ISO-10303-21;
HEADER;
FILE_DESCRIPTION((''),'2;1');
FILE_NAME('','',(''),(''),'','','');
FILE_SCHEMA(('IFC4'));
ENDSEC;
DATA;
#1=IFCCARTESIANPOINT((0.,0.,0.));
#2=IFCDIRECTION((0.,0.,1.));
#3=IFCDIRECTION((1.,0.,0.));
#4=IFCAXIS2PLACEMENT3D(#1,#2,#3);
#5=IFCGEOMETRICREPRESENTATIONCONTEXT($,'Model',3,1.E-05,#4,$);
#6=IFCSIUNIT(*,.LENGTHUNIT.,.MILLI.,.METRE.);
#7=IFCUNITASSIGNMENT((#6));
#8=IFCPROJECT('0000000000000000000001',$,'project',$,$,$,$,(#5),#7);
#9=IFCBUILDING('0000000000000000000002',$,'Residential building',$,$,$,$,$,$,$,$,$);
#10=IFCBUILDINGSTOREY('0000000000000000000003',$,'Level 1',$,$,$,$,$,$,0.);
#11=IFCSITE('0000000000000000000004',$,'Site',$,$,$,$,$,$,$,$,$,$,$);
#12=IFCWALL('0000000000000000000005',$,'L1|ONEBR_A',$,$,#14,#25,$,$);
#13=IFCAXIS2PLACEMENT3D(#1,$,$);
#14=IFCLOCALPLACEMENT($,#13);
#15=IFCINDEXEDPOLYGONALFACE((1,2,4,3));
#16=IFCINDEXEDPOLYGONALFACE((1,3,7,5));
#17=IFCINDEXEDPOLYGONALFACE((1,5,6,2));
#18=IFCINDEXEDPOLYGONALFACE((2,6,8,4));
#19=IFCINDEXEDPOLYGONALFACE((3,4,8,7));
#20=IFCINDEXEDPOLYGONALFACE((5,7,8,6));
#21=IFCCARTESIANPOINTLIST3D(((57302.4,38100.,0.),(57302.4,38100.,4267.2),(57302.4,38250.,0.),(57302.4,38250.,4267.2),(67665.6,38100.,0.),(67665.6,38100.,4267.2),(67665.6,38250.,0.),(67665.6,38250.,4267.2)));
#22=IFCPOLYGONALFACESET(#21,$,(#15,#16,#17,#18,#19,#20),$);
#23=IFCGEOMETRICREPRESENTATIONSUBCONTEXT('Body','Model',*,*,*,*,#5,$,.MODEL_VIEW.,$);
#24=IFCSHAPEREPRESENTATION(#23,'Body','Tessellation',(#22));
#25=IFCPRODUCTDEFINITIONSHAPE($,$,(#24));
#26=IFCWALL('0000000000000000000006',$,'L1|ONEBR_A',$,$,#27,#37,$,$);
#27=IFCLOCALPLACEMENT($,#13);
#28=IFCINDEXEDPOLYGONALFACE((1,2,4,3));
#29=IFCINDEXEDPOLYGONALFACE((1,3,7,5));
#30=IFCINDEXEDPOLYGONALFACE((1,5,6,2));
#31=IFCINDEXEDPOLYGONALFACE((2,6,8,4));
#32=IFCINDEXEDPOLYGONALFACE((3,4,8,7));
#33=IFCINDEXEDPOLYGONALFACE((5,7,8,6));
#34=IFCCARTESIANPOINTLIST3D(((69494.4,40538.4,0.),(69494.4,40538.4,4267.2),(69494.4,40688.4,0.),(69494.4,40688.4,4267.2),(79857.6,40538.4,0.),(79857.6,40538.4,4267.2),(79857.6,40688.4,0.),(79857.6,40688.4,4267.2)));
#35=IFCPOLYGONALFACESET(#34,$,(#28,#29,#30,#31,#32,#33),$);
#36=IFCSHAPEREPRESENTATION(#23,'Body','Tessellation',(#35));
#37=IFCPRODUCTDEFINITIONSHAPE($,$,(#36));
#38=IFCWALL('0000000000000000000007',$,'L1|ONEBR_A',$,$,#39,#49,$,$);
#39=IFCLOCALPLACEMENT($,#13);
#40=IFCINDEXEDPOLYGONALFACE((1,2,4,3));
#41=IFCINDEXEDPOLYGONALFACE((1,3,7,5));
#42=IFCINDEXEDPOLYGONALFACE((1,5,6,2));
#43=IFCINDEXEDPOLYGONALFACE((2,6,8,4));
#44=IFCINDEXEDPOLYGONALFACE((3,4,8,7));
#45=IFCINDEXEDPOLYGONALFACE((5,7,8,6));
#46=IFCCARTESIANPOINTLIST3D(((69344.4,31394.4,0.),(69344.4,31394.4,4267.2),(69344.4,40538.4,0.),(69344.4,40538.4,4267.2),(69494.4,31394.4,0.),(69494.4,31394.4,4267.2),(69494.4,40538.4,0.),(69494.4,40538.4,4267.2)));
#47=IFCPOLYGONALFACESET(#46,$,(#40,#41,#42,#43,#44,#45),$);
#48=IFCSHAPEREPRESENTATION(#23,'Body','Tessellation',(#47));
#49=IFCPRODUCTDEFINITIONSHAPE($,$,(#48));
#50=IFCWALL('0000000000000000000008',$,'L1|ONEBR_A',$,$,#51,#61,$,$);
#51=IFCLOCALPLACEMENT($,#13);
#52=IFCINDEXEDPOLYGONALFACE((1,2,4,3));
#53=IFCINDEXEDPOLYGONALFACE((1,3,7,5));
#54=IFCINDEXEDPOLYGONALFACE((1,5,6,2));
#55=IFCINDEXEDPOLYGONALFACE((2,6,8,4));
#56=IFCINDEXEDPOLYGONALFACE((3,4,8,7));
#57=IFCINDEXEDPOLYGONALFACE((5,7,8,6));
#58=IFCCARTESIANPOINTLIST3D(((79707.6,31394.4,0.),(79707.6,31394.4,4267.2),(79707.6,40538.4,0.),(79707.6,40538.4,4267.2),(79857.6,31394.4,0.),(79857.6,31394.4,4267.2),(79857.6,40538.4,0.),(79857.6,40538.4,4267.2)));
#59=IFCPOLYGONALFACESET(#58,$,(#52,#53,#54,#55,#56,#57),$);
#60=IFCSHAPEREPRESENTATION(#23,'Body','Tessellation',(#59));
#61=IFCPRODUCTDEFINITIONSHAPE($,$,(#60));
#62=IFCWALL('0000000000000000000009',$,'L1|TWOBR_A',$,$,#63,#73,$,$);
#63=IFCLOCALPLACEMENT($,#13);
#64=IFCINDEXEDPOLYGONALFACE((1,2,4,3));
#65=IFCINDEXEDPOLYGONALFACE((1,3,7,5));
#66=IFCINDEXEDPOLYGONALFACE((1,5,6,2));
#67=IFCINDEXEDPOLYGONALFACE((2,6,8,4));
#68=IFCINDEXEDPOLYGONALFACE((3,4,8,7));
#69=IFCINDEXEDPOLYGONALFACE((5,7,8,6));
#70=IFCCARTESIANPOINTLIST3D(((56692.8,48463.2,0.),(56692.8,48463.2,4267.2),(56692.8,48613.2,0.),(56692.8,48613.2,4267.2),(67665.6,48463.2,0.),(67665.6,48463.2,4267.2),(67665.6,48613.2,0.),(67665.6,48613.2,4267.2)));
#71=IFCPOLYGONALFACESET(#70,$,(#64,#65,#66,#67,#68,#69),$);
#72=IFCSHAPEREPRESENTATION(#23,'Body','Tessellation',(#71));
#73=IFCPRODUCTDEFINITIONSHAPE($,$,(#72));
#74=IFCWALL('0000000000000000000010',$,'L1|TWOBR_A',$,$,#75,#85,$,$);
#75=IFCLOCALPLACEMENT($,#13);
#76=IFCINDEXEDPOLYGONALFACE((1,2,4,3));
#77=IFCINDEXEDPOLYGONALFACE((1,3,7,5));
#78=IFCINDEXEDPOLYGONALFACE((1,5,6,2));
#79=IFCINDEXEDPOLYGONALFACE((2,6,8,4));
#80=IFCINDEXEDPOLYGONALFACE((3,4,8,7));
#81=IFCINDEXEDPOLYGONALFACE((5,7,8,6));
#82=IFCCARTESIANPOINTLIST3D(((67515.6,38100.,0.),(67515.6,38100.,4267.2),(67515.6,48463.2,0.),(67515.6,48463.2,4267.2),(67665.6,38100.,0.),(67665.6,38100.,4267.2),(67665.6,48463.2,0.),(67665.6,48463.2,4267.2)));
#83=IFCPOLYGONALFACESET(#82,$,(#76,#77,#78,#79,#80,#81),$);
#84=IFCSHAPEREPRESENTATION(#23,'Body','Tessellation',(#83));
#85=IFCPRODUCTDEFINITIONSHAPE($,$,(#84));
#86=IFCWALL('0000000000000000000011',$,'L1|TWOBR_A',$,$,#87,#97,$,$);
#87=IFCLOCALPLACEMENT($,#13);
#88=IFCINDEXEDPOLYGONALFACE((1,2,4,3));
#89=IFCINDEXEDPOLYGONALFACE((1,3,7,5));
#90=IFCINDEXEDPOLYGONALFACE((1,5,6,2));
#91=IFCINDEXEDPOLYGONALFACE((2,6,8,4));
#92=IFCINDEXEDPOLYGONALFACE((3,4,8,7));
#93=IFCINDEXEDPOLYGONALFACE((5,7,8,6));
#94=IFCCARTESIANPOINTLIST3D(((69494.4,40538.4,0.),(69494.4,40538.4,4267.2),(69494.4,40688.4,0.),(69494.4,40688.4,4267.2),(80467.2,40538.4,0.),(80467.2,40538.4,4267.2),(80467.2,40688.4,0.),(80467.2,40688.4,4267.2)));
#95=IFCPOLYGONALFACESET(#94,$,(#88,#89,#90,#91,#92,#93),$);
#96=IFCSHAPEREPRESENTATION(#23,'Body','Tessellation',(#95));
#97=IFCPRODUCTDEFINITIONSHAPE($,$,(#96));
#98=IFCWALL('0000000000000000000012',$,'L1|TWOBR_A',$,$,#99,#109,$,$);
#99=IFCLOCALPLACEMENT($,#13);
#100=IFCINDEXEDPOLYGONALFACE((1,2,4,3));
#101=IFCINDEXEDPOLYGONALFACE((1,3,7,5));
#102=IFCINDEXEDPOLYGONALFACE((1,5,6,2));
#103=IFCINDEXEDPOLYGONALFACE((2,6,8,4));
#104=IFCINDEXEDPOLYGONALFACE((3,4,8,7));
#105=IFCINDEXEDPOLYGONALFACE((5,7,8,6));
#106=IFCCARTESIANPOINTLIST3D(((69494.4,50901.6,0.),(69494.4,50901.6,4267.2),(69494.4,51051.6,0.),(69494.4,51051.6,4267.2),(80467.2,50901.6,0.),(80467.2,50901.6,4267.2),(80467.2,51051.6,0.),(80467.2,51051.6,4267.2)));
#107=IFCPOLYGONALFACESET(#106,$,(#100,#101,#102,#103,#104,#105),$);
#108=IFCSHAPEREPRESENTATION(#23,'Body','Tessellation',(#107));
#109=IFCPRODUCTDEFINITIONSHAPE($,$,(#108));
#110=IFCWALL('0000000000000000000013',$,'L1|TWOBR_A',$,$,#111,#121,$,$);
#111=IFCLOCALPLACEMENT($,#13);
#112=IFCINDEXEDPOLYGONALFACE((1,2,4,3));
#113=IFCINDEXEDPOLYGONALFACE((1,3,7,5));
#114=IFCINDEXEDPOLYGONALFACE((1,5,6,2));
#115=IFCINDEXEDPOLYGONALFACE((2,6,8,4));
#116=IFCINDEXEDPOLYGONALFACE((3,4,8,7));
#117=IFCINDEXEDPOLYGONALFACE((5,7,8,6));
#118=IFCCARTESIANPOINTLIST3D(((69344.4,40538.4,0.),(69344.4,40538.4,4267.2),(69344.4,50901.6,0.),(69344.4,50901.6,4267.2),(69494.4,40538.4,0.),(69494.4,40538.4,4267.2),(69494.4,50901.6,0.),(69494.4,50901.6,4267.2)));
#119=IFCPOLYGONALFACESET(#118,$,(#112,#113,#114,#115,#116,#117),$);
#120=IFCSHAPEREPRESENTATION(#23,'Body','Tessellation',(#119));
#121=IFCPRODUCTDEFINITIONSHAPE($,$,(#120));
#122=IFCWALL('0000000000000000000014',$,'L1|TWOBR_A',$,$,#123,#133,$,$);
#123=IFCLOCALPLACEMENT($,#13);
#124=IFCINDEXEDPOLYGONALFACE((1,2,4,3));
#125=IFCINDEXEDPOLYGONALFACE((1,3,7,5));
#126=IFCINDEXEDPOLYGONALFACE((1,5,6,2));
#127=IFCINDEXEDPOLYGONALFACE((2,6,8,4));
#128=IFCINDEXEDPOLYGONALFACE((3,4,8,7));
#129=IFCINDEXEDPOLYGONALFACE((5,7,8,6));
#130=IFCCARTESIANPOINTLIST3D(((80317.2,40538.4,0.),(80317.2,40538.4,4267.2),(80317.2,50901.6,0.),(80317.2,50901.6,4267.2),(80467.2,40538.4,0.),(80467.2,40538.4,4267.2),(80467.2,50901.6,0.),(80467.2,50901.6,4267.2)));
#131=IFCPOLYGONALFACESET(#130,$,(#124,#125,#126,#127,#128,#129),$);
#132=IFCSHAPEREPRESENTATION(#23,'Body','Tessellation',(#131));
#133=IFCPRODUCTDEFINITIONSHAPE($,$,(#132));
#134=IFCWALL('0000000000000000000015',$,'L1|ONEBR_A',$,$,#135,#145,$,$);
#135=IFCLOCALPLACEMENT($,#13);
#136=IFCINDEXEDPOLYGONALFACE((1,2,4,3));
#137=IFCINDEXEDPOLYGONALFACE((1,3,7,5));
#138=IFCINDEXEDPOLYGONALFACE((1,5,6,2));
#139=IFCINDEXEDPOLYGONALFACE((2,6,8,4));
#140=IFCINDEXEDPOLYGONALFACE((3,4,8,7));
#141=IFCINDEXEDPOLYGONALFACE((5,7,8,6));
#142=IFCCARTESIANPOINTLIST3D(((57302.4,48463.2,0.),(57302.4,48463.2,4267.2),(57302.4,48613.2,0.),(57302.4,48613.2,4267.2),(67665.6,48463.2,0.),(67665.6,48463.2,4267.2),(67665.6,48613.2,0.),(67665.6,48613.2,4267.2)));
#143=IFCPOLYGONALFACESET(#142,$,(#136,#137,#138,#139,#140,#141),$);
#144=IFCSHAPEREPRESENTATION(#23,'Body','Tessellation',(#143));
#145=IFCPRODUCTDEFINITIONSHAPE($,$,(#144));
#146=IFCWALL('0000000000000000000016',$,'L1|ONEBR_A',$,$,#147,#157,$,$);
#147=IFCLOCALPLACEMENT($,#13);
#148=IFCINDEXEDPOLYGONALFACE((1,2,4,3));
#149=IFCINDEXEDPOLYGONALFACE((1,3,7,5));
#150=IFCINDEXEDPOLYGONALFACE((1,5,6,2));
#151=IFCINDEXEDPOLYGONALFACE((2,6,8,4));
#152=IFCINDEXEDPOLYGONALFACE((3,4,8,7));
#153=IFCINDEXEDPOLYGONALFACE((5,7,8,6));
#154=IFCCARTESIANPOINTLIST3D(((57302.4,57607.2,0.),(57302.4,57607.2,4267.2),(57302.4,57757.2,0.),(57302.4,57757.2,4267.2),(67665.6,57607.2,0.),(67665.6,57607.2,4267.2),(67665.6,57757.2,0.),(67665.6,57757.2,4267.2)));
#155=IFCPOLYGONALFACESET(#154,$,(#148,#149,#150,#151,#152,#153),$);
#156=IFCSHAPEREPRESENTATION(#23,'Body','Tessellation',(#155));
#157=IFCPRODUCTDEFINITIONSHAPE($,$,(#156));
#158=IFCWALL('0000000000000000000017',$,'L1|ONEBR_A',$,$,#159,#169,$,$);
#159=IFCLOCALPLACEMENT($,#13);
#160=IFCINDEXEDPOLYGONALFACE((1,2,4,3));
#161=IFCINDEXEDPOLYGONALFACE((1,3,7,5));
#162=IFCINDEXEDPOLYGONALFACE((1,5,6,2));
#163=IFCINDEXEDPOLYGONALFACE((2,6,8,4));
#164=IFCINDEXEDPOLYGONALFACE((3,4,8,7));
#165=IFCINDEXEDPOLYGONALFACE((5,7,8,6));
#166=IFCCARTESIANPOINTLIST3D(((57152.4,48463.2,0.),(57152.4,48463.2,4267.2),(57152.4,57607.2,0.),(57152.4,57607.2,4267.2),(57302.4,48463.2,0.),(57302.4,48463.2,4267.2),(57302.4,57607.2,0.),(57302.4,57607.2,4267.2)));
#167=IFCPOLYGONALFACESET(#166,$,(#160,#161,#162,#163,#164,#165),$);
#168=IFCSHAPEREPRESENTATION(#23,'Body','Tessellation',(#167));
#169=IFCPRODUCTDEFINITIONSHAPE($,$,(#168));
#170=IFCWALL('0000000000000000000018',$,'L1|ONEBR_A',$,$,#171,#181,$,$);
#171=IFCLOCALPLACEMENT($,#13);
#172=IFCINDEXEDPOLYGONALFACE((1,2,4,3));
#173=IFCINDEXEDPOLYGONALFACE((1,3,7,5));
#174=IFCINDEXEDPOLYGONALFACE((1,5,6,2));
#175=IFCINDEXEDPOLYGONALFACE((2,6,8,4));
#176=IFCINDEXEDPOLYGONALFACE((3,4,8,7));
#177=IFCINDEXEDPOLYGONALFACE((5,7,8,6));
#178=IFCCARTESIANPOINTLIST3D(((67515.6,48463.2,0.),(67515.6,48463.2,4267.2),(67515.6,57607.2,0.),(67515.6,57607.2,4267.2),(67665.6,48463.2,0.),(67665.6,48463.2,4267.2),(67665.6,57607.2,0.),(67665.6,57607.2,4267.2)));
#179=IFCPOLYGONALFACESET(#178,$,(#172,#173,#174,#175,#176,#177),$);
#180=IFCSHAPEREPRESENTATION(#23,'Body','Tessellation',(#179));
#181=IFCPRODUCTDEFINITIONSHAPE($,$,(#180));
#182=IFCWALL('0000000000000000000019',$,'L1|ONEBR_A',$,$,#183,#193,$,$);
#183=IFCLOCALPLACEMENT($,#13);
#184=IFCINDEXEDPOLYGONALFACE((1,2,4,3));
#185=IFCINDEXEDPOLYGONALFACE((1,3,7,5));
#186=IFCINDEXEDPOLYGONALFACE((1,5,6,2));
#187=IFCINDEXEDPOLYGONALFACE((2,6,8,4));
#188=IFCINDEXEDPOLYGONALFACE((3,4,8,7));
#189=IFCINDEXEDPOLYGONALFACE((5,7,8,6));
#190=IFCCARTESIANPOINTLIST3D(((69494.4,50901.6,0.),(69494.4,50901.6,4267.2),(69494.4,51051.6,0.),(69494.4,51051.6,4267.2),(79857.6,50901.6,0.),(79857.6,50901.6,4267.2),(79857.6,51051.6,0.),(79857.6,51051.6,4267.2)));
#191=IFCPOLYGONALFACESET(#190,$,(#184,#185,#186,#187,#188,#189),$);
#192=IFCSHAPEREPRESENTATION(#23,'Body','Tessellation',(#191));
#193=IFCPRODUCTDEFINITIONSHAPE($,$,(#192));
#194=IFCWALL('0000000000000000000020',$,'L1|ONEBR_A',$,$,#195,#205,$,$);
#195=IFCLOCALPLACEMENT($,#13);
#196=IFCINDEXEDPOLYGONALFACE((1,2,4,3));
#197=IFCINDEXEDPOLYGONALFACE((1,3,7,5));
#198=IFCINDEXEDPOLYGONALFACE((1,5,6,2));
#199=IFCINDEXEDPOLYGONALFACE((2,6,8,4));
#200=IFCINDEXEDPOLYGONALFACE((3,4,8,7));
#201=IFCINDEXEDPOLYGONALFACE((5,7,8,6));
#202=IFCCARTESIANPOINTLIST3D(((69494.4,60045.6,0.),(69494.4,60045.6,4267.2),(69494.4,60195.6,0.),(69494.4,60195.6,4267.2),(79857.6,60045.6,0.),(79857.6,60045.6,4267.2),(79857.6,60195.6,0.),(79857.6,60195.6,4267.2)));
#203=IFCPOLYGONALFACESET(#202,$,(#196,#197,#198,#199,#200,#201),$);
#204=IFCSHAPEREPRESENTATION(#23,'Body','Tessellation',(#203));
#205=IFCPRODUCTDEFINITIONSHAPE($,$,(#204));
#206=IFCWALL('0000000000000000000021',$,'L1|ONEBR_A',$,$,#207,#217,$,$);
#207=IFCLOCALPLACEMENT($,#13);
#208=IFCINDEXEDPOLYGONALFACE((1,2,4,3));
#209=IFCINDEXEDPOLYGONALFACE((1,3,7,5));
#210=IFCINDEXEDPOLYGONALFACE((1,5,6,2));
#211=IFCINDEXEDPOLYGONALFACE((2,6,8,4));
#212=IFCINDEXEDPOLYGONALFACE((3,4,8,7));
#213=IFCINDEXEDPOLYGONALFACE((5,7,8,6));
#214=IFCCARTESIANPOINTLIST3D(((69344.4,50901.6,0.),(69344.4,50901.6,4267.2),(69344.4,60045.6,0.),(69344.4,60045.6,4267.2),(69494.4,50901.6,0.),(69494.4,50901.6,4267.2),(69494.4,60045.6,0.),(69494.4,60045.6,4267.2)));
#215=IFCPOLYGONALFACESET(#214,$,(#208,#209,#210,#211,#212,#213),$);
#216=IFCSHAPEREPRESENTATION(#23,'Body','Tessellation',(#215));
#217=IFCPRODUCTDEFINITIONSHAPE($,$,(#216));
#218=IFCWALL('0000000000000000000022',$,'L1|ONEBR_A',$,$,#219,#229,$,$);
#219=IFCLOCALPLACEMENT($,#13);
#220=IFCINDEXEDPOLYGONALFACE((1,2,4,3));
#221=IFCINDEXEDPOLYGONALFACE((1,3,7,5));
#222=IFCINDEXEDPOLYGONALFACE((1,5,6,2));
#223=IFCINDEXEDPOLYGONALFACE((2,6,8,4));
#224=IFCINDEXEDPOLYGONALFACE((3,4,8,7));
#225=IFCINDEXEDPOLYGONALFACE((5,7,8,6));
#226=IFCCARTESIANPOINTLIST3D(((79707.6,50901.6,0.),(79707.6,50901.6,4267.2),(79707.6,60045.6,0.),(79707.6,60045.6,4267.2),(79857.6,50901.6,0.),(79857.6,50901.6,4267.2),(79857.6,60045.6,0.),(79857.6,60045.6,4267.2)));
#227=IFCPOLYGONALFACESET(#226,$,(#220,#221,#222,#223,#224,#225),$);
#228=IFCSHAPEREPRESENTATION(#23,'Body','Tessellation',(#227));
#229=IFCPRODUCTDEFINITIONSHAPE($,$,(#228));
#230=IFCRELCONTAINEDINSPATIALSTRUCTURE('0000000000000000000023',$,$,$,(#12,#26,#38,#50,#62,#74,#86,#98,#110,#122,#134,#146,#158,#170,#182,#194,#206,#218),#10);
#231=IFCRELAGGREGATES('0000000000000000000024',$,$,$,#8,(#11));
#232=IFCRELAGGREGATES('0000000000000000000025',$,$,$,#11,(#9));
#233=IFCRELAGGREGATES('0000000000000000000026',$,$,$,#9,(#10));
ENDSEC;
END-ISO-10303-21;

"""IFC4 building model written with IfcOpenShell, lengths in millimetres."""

from ifc_helpers import new_model, si_unit, frame, origin_with_axes, place, context, subcontext, project, spatial, indexed_curve, outline, extrude, element, save


model = new_model("IFC4")

# Units and contexts
model_context = context("Model", 3, precision=1e-05, world=origin_with_axes())
body_context = subcontext(model_context, "Body", "Model", "MODEL_VIEW")
ifc_project = project(units=[si_unit("LENGTHUNIT", "METRE", prefix="MILLI")], contexts=[model_context])

# Site, building, storey
site = spatial("IfcSite", under=ifc_project, Name="Site")
building = spatial("IfcBuilding", under=site, Name="Residential building")
storey = spatial("IfcBuildingStorey", under=building, Name="Level 1", Elevation=0.0)

# Walls
for number, where, z_axis, x_axis, name in (
    (1, (57302.4, 38100.0, 0.0), (0.0, 0.0, 1.0), (1.0, 0.0, 0.0), "L1|ONEBR_A"),
    (2, (69494.4, 40538.4, 0.0), (0.0, 0.0, 1.0), (1.0, 0.0, 0.0), "L1|ONEBR_A"),
):
    element("IfcWall", number, at=place(None, frame(where, z_axis=z_axis, x_axis=x_axis)), inside=storey, Name=name, context=body_context, shape_type="SweptSolid", body=[
        extrude(outline(indexed_curve([(0.0, 0.0), (0.0, 150.0), (10363.2, 150.0), (10363.2, 0.0), (0.0, 0.0)], self_intersect=False)), origin_with_axes(), (0.0, 0.0, 1.0), 4267.2),
    ])
for number, where, z_axis, x_axis, name in (
    (3, (69494.4, 31394.4, 0.0), (0.0, 0.0, 1.0), (0.0, 1.0, 0.0), "L1|ONEBR_A"),
    (4, (79857.6, 31394.4, 0.0), (0.0, 0.0, 1.0), (0.0, 1.0, 0.0), "L1|ONEBR_A"),
):
    element("IfcWall", number, at=place(None, frame(where, z_axis=z_axis, x_axis=x_axis)), inside=storey, Name=name, context=body_context, shape_type="SweptSolid", body=[
        extrude(outline(indexed_curve([(0.0, 0.0), (0.0, 150.0), (9144.0, 150.0), (9144.0, 0.0), (0.0, 0.0)], self_intersect=False)), origin_with_axes(), (0.0, 0.0, 1.0), 4267.2),
    ])
wall_1_placement = place(None, frame((56692.8, 48463.2, 0.0), z_axis=(0.0, 0.0, 1.0), x_axis=(1.0, 0.0, 0.0)))
element("IfcWall", 5, at=wall_1_placement, inside=storey, Name="L1|TWOBR_A", context=body_context, shape_type="SweptSolid", body=[
    extrude(outline(indexed_curve([(0.0, 0.0), (0.0, 150.0), (10972.8, 150.0), (10972.8, 0.0), (0.0, 0.0)], self_intersect=False)), origin_with_axes(), (0.0, 0.0, 1.0), 4267.2),
])
wall_2_placement = place(None, frame((67665.6, 38100.0, 0.0), z_axis=(0.0, 0.0, 1.0), x_axis=(0.0, 1.0, 0.0)))
element("IfcWall", 6, at=wall_2_placement, inside=storey, Name="L1|TWOBR_A", context=body_context, shape_type="SweptSolid", body=[
    extrude(outline(indexed_curve([(0.0, 0.0), (0.0, 150.0), (10363.2, 150.0), (10363.2, 0.0), (0.0, 0.0)], self_intersect=False)), origin_with_axes(), (0.0, 0.0, 1.0), 4267.2),
])
for number, where, z_axis, x_axis, name in (
    (7, (69494.4, 40538.4, 0.0), (0.0, 0.0, 1.0), (1.0, 0.0, 0.0), "L1|TWOBR_A"),
    (8, (69494.4, 50901.6, 0.0), (0.0, 0.0, 1.0), (1.0, 0.0, 0.0), "L1|TWOBR_A"),
):
    element("IfcWall", number, at=place(None, frame(where, z_axis=z_axis, x_axis=x_axis)), inside=storey, Name=name, context=body_context, shape_type="SweptSolid", body=[
        extrude(outline(indexed_curve([(0.0, 0.0), (0.0, 150.0), (10972.8, 150.0), (10972.8, 0.0), (0.0, 0.0)], self_intersect=False)), origin_with_axes(), (0.0, 0.0, 1.0), 4267.2),
    ])
for number, where, z_axis, x_axis, name in (
    (9, (69494.4, 40538.4, 0.0), (0.0, 0.0, 1.0), (0.0, 1.0, 0.0), "L1|TWOBR_A"),
    (10, (80467.2, 40538.4, 0.0), (0.0, 0.0, 1.0), (0.0, 1.0, 0.0), "L1|TWOBR_A"),
    (11, (57302.4, 48463.2, 0.0), (0.0, 0.0, 1.0), (1.0, 0.0, 0.0), "L1|ONEBR_A"),
    (12, (57302.4, 57607.2, 0.0), (0.0, 0.0, 1.0), (1.0, 0.0, 0.0), "L1|ONEBR_A"),
):
    element("IfcWall", number, at=place(None, frame(where, z_axis=z_axis, x_axis=x_axis)), inside=storey, Name=name, context=body_context, shape_type="SweptSolid", body=[
        extrude(outline(indexed_curve([(0.0, 0.0), (0.0, 150.0), (10363.2, 150.0), (10363.2, 0.0), (0.0, 0.0)], self_intersect=False)), origin_with_axes(), (0.0, 0.0, 1.0), 4267.2),
    ])
for number, where, z_axis, x_axis, name in (
    (13, (57302.4, 48463.2, 0.0), (0.0, 0.0, 1.0), (0.0, 1.0, 0.0), "L1|ONEBR_A"),
    (14, (67665.6, 48463.2, 0.0), (0.0, 0.0, 1.0), (0.0, 1.0, 0.0), "L1|ONEBR_A"),
):
    element("IfcWall", number, at=place(None, frame(where, z_axis=z_axis, x_axis=x_axis)), inside=storey, Name=name, context=body_context, shape_type="SweptSolid", body=[
        extrude(outline(indexed_curve([(0.0, 0.0), (0.0, 150.0), (9144.0, 150.0), (9144.0, 0.0), (0.0, 0.0)], self_intersect=False)), origin_with_axes(), (0.0, 0.0, 1.0), 4267.2),
    ])
for number, where, z_axis, x_axis, name in (
    (15, (69494.4, 50901.6, 0.0), (0.0, 0.0, 1.0), (1.0, 0.0, 0.0), "L1|ONEBR_A"),
    (16, (69494.4, 60045.6, 0.0), (0.0, 0.0, 1.0), (1.0, 0.0, 0.0), "L1|ONEBR_A"),
):
    element("IfcWall", number, at=place(None, frame(where, z_axis=z_axis, x_axis=x_axis)), inside=storey, Name=name, context=body_context, shape_type="SweptSolid", body=[
        extrude(outline(indexed_curve([(0.0, 0.0), (0.0, 150.0), (10363.2, 150.0), (10363.2, 0.0), (0.0, 0.0)], self_intersect=False)), origin_with_axes(), (0.0, 0.0, 1.0), 4267.2),
    ])
for number, where, z_axis, x_axis, name in (
    (17, (69494.4, 50901.6, 0.0), (0.0, 0.0, 1.0), (0.0, 1.0, 0.0), "L1|ONEBR_A"),
    (18, (79857.6, 50901.6, 0.0), (0.0, 0.0, 1.0), (0.0, 1.0, 0.0), "L1|ONEBR_A"),
):
    element("IfcWall", number, at=place(None, frame(where, z_axis=z_axis, x_axis=x_axis)), inside=storey, Name=name, context=body_context, shape_type="SweptSolid", body=[
        extrude(outline(indexed_curve([(0.0, 0.0), (0.0, 150.0), (9144.0, 150.0), (9144.0, 0.0), (0.0, 0.0)], self_intersect=False)), origin_with_axes(), (0.0, 0.0, 1.0), 4267.2),
    ])

save(model, "model.ifc")
